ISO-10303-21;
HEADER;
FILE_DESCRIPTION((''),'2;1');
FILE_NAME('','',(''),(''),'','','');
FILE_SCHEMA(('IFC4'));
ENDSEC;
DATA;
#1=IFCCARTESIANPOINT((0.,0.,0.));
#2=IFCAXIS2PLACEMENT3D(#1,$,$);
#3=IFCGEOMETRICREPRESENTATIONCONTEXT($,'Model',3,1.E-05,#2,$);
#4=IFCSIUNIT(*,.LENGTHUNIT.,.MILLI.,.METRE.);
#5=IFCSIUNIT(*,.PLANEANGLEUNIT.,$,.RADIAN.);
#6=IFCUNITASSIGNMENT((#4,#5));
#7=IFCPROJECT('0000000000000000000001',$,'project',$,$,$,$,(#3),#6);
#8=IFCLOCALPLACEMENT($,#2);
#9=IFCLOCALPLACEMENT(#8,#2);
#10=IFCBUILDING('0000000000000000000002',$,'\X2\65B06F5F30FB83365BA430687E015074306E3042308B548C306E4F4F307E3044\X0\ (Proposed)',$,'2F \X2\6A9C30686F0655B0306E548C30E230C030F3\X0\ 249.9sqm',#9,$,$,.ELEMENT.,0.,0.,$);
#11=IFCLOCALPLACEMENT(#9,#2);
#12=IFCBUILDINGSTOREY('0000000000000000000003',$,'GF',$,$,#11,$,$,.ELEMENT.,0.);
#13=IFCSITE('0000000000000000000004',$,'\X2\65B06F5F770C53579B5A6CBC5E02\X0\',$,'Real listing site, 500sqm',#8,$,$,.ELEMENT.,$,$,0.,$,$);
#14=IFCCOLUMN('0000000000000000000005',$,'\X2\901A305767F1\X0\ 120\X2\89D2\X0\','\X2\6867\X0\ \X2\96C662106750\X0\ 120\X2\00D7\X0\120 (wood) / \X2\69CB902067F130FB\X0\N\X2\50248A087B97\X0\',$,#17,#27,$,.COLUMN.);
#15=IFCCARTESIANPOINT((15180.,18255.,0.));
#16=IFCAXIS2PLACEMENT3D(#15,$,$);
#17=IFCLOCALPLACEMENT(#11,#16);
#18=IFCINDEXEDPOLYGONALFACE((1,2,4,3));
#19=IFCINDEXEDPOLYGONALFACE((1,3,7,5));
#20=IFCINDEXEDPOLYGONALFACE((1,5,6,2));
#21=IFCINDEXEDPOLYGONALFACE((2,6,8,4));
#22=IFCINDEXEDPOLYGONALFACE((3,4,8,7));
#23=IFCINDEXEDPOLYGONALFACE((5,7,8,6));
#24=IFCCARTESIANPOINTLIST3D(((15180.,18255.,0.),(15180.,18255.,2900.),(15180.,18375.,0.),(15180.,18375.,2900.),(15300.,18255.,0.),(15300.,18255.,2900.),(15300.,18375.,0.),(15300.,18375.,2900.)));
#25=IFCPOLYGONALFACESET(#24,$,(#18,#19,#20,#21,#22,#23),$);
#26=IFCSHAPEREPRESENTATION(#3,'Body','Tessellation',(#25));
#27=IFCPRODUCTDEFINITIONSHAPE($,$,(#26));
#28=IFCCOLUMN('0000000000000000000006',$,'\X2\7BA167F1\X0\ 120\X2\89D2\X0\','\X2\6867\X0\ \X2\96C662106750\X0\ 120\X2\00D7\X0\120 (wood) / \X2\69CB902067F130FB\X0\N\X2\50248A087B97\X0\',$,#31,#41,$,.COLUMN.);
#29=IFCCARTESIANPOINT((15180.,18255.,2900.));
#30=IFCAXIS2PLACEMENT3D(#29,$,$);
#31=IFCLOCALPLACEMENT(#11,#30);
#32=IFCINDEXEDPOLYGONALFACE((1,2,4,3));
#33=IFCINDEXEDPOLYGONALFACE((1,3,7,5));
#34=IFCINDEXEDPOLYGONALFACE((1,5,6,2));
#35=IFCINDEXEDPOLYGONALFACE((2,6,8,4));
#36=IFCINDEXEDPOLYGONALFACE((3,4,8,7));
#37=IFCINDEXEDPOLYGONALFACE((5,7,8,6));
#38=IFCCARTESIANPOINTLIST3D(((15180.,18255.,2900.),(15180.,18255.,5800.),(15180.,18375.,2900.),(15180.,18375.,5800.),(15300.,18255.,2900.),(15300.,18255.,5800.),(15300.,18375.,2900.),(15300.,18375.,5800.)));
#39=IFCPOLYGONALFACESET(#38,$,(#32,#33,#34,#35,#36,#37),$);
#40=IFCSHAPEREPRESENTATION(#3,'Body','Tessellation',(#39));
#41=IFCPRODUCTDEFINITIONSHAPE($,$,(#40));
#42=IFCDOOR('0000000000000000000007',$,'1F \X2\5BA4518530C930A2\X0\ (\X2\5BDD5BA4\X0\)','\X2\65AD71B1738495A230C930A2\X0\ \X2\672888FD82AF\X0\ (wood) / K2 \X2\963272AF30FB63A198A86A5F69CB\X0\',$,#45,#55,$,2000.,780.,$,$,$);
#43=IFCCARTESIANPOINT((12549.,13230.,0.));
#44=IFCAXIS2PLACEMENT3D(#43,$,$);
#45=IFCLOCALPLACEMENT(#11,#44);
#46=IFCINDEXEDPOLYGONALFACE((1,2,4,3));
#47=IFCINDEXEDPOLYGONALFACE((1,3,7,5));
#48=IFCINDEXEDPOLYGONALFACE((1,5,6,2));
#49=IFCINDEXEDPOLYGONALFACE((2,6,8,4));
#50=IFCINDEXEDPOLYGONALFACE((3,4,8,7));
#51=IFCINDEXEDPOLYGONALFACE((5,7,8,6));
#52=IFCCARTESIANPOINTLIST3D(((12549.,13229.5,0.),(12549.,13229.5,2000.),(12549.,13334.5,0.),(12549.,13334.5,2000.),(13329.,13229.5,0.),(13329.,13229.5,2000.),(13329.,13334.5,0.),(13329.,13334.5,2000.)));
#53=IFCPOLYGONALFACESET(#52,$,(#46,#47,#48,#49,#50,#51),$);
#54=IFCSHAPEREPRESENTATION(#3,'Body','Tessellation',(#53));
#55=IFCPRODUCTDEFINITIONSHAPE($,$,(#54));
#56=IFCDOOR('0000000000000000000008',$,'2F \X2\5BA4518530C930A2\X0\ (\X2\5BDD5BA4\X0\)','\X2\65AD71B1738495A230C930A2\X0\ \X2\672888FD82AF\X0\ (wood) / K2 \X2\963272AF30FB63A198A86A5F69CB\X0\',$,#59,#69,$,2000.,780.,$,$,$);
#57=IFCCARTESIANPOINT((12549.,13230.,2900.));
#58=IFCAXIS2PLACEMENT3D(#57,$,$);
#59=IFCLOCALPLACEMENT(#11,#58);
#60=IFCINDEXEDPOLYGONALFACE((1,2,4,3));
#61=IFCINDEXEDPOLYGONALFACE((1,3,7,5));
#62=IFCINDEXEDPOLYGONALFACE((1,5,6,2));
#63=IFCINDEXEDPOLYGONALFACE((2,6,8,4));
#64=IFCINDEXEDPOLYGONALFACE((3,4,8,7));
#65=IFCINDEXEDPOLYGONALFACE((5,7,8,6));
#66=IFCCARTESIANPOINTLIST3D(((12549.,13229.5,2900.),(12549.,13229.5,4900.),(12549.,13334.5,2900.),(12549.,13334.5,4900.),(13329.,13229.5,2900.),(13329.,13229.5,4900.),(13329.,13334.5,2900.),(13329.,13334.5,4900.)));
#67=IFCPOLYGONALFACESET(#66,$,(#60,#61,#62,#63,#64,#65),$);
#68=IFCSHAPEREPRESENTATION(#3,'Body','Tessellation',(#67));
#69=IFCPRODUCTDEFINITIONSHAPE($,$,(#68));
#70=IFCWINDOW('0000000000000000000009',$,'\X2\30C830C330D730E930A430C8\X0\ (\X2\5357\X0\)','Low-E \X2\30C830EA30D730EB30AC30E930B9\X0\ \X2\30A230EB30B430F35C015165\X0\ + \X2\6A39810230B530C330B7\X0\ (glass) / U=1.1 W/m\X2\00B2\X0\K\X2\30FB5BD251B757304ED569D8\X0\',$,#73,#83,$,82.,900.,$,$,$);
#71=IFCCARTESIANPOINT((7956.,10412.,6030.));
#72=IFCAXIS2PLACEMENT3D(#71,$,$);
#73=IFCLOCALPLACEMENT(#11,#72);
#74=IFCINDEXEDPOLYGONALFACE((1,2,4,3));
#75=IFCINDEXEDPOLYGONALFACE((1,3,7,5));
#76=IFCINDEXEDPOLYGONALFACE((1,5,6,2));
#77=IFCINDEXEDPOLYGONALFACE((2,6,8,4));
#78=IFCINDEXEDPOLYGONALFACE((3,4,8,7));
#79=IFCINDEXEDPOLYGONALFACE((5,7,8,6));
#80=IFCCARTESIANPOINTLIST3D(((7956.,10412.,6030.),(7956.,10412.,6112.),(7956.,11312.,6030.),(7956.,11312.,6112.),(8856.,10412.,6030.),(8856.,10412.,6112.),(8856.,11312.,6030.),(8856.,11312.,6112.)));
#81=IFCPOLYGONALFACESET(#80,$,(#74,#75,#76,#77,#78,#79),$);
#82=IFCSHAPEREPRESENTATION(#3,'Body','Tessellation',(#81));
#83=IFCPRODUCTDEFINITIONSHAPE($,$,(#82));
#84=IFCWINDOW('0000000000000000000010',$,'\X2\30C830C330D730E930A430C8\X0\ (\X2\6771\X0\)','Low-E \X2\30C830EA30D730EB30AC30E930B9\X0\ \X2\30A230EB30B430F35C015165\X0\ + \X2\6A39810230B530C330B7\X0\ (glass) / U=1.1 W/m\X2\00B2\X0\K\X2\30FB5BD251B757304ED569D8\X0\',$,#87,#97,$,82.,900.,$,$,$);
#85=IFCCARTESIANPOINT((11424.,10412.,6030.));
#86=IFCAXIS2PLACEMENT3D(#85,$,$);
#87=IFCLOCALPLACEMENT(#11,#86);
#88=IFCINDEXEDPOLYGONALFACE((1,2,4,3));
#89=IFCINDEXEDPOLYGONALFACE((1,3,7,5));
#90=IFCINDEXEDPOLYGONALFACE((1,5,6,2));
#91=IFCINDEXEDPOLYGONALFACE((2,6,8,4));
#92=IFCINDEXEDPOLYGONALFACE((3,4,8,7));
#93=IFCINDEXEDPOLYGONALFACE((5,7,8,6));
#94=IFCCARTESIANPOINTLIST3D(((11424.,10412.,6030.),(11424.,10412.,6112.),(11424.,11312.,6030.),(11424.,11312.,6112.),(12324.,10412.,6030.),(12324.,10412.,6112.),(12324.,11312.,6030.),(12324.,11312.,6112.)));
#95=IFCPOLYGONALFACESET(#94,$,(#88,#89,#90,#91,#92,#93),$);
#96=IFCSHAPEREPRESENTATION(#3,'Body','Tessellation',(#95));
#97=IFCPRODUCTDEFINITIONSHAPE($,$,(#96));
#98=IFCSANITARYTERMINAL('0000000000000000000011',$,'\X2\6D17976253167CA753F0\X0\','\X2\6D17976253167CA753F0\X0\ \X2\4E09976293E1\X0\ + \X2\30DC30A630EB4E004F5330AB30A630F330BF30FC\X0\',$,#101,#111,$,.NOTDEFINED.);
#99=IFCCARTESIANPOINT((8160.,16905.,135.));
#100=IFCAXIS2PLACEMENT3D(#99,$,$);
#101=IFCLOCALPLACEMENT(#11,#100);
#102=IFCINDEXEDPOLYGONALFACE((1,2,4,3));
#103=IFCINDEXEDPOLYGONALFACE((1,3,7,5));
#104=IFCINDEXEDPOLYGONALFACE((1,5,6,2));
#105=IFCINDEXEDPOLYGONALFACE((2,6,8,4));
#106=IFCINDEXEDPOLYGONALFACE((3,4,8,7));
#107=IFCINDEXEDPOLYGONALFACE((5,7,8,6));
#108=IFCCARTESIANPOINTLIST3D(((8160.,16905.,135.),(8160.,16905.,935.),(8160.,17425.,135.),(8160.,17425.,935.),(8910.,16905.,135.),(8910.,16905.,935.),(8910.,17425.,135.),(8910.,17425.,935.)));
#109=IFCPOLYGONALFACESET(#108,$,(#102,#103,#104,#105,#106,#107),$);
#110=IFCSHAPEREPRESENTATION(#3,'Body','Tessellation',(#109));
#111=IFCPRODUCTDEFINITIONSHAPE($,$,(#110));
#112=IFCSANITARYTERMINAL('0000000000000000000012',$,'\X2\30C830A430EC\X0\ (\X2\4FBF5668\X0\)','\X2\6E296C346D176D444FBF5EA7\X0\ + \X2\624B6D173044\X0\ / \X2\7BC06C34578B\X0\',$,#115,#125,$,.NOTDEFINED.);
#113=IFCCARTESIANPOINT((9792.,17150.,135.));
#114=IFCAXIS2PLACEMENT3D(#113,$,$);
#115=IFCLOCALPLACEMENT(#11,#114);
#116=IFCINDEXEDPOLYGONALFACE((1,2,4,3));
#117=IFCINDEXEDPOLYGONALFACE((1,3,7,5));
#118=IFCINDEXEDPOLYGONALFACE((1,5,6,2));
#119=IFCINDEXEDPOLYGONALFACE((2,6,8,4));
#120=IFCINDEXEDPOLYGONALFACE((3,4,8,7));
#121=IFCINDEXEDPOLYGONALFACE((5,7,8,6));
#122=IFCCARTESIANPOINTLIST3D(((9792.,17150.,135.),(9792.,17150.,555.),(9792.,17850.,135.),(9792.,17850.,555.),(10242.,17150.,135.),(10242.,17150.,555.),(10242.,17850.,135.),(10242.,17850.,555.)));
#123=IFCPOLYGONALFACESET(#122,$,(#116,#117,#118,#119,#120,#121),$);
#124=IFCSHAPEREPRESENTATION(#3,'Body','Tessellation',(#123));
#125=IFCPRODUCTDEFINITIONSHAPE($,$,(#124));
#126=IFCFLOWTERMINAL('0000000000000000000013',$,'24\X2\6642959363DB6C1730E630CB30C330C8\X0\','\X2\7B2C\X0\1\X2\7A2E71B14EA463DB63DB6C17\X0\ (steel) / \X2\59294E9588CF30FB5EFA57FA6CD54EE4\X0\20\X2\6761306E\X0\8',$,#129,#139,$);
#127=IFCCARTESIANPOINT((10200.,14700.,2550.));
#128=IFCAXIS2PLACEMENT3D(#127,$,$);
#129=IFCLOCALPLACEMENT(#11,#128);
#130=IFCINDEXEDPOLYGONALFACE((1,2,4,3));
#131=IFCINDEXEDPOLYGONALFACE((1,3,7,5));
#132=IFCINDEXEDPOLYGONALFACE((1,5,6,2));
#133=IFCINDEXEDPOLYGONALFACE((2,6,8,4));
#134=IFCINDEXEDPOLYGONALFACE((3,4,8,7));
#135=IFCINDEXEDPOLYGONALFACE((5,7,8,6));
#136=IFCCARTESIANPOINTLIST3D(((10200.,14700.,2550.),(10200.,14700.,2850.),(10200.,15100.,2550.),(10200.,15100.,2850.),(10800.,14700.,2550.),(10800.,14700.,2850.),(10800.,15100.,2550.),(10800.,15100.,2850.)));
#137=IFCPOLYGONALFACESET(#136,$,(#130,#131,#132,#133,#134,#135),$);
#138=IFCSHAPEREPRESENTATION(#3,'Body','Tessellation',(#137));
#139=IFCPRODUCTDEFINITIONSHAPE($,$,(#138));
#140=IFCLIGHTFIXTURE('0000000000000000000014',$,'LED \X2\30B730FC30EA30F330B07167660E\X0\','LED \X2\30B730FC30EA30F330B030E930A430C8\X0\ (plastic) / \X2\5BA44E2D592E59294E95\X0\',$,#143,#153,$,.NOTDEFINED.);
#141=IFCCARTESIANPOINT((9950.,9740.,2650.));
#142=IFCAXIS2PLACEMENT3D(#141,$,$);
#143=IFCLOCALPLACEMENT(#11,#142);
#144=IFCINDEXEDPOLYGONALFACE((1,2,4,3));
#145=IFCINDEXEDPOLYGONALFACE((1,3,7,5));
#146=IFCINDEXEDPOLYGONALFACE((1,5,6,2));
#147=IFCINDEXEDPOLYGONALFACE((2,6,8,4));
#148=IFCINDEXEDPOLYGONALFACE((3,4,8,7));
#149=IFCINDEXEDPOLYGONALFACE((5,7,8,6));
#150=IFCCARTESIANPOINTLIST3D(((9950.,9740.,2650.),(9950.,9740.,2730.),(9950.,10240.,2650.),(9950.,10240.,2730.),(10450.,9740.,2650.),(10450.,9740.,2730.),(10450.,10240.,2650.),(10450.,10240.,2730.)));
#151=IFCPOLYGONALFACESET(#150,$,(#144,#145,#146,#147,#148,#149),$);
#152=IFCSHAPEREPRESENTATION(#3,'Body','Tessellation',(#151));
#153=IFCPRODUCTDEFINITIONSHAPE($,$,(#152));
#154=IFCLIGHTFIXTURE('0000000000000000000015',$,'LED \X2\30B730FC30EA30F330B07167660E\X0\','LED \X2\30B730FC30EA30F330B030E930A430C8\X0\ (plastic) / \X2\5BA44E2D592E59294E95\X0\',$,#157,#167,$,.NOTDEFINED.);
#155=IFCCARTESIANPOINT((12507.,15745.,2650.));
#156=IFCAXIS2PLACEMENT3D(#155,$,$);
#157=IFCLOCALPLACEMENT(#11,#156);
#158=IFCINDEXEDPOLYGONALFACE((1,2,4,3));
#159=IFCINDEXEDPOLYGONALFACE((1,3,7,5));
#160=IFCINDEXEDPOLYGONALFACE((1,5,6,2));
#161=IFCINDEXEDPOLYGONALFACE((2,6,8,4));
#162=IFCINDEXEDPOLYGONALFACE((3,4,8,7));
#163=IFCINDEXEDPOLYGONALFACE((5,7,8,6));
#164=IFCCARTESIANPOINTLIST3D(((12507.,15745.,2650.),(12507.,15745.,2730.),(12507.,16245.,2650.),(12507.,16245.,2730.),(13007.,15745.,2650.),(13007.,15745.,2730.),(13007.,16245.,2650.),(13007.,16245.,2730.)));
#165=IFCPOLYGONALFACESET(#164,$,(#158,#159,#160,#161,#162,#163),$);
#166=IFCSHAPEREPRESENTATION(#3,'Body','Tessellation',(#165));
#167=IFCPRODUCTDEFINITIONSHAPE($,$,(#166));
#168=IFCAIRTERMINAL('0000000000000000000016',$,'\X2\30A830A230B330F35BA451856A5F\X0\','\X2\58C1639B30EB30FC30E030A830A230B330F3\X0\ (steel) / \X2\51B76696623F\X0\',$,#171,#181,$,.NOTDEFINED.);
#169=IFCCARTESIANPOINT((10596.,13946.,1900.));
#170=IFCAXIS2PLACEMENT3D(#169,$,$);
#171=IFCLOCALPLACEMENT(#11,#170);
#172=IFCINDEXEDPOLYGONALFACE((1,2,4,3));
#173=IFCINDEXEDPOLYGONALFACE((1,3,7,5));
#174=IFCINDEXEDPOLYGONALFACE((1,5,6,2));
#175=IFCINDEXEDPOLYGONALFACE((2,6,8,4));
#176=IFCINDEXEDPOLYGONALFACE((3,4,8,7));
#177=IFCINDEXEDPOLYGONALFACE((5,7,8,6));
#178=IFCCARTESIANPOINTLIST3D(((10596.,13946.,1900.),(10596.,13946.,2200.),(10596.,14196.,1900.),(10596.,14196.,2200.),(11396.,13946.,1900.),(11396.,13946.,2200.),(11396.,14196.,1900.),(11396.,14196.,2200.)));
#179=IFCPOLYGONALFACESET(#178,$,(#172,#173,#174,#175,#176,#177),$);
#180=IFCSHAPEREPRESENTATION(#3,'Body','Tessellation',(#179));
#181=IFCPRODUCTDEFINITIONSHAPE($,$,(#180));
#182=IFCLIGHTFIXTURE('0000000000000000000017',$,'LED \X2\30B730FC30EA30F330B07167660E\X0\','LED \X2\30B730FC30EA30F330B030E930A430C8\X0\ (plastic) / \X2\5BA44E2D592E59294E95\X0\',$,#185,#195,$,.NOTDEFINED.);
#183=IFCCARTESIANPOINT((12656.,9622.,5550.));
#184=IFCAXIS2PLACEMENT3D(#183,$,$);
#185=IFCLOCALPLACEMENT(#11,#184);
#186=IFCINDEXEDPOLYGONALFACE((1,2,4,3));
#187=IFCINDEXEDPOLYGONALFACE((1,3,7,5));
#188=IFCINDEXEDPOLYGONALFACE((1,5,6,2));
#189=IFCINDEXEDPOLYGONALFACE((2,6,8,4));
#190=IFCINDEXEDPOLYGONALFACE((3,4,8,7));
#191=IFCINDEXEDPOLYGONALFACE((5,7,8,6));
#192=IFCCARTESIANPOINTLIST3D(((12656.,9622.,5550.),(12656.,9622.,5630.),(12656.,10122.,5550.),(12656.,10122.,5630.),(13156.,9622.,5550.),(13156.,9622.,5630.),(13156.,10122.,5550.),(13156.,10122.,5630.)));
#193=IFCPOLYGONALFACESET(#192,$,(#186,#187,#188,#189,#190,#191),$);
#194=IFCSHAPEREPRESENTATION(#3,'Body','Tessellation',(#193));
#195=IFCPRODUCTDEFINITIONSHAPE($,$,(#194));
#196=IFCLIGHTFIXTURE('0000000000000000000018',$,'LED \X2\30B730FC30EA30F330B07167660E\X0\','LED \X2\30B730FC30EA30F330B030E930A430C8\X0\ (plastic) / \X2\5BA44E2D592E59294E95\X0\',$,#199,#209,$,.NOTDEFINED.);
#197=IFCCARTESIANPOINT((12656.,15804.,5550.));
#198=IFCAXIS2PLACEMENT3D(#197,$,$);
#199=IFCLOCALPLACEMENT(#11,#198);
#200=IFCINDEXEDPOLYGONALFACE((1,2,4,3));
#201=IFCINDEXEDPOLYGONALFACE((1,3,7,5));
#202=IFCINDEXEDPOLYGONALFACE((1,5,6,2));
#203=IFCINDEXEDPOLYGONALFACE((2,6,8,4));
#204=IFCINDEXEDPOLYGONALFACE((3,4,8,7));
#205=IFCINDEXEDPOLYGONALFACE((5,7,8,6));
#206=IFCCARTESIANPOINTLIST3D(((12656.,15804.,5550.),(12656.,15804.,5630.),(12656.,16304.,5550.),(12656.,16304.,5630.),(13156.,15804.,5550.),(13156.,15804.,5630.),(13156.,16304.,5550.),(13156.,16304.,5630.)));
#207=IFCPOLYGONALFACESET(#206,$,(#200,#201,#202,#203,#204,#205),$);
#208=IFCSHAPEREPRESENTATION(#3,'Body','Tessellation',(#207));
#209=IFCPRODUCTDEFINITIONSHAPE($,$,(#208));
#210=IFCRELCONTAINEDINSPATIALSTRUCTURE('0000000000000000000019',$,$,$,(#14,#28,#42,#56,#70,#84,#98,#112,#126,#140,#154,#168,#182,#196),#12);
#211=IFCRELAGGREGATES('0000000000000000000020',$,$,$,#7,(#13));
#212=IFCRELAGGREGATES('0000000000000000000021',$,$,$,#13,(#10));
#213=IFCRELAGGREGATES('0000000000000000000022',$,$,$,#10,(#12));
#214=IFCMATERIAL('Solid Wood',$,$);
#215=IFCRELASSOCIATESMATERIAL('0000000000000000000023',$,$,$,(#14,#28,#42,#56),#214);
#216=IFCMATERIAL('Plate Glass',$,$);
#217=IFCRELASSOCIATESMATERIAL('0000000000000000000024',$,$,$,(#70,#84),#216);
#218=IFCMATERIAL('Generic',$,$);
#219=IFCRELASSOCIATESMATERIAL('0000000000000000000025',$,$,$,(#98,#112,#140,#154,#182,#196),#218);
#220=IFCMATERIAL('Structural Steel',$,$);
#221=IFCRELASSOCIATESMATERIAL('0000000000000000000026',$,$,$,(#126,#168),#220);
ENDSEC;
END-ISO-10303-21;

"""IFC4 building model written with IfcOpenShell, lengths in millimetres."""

from ifc_helpers import new_model, si_unit, frame, frame_2d, origin, place, context, project, spatial, rectangle, extrude, material, element, save


model = new_model("IFC4")

# Units and contexts
model_context = context("Model", 3, precision=1e-05, world=origin())
ifc_project = project(units=[si_unit("LENGTHUNIT", "METRE", prefix="MILLI"), si_unit("PLANEANGLEUNIT", "RADIAN")], contexts=[model_context])

# Site, building, storey
site_placement = place(None, origin())
site = spatial("IfcSite", under=ifc_project, at=site_placement, Name="新潟県南魚沼市", ObjectType="Real listing site, 500sqm", CompositionType="ELEMENT", RefElevation=0.0)
building_placement = place(site_placement, origin())
building = spatial("IfcBuilding", under=site, at=building_placement, Name="新潟・茶室と縁側のある和の住まい (Proposed)", ObjectType="2F 檜と漆喰の和モダン 249.9sqm", CompositionType="ELEMENT", ElevationOfRefHeight=0.0, ElevationOfTerrain=0.0)
storey_placement = place(building_placement, origin())
storey = spatial("IfcBuildingStorey", under=building, at=storey_placement, Name="GF", CompositionType="ELEMENT", Elevation=0.0)

# Columns
ifc_material_1 = material(Name="Solid Wood")
column_1_placement = place(storey_placement, frame((15180.0, 18255.0, 0.0)))
element("IfcColumn", 1, at=column_1_placement, inside=storey, material=ifc_material_1, Name="通し柱 120角", Description="桧 集成材 120×120 (wood) / 構造柱・N値計算", PredefinedType="COLUMN", context=model_context, shape_type="SweptSolid", body=[
    extrude(rectangle(XDim=120.0, YDim=120.0, at=frame_2d((60.0, 60.0))), frame((15180.0, 18255.0, 0.0)), (0.0, 0.0, 1.0), 2900.0),
])
column_2_placement = place(storey_placement, frame((15180.0, 18255.0, 2900.0)))
element("IfcColumn", 2, at=column_2_placement, inside=storey, material=ifc_material_1, Name="管柱 120角", Description="桧 集成材 120×120 (wood) / 構造柱・N値計算", PredefinedType="COLUMN", context=model_context, shape_type="SweptSolid", body=[
    extrude(rectangle(XDim=120.0, YDim=120.0, at=frame_2d((60.0, 60.0))), frame((15180.0, 18255.0, 2900.0)), (0.0, 0.0, 1.0), 2900.0),
])

# Door
door_1_placement = place(storey_placement, frame((12549.0, 13230.0, 0.0)))
element("IfcDoor", 3, at=door_1_placement, inside=storey, material=ifc_material_1, Name="1F 室内ドア (寝室)", Description="断熱玄関ドア 木製芯 (wood) / K2 防犯・採風機構", OverallHeight=2000.0, OverallWidth=780.0, context=model_context, shape_type="SweptSolid", body=[
    extrude(rectangle(XDim=780.0, YDim=105.0, at=frame_2d((390.0, 52.0))), frame((12549.0, 13230.0, 0.0)), (0.0, 0.0, 1.0), 2000.0),
])

# Door
door_2_placement = place(storey_placement, frame((12549.0, 13230.0, 2900.0)))
element("IfcDoor", 4, at=door_2_placement, inside=storey, material=ifc_material_1, Name="2F 室内ドア (寝室)", Description="断熱玄関ドア 木製芯 (wood) / K2 防犯・採風機構", OverallHeight=2000.0, OverallWidth=780.0, context=model_context, shape_type="SweptSolid", body=[
    extrude(rectangle(XDim=780.0, YDim=105.0, at=frame_2d((390.0, 52.0))), frame((12549.0, 13230.0, 2900.0)), (0.0, 0.0, 1.0), 2000.0),
])

# Windows
ifc_material_2 = material(Name="Plate Glass")
window_1_placement = place(storey_placement, frame((7956.0, 10412.0, 6030.0)))
element("IfcWindow", 5, at=window_1_placement, inside=storey, material=ifc_material_2, Name="トップライト (南)", Description="Low-E トリプルガラス アルゴン封入 + 樹脂サッシ (glass) / U=1.1 W/m²K・寒冷地仕様", OverallHeight=82.0, OverallWidth=900.0, context=model_context, shape_type="SweptSolid", body=[
    extrude(rectangle(XDim=900.0, YDim=900.0, at=frame_2d((450.0, 450.0))), frame((7956.0, 10412.0, 6030.0)), (0.0, 0.0, 1.0), 82.0),
])
window_2_placement = place(storey_placement, frame((11424.0, 10412.0, 6030.0)))
element("IfcWindow", 6, at=window_2_placement, inside=storey, material=ifc_material_2, Name="トップライト (東)", Description="Low-E トリプルガラス アルゴン封入 + 樹脂サッシ (glass) / U=1.1 W/m²K・寒冷地仕様", OverallHeight=82.0, OverallWidth=900.0, context=model_context, shape_type="SweptSolid", body=[
    extrude(rectangle(XDim=900.0, YDim=900.0, at=frame_2d((450.0, 450.0))), frame((11424.0, 10412.0, 6030.0)), (0.0, 0.0, 1.0), 82.0),
])

# Sanitary terminals
ifc_material_3 = material(Name="Generic")
sanitary_terminal_1_placement = place(storey_placement, frame((8160.0, 16905.0, 135.0)))
element("IfcSanitaryTerminal", 7, at=sanitary_terminal_1_placement, inside=storey, material=ifc_material_3, Name="洗面化粧台", Description="洗面化粧台 三面鏡 + ボウル一体カウンター", PredefinedType="NOTDEFINED", context=model_context, shape_type="SweptSolid", body=[
    extrude(rectangle(XDim=750.0, YDim=520.0, at=frame_2d((375.0, 260.0))), frame((8160.0, 16905.0, 135.0)), (0.0, 0.0, 1.0), 800.0),
])
sanitary_terminal_2_placement = place(storey_placement, frame((9792.0, 17150.0, 135.0)))
element("IfcSanitaryTerminal", 8, at=sanitary_terminal_2_placement, inside=storey, material=ifc_material_3, Name="トイレ (便器)", Description="温水洗浄便座 + 手洗い / 節水型", PredefinedType="NOTDEFINED", context=model_context, shape_type="SweptSolid", body=[
    extrude(rectangle(XDim=450.0, YDim=700.0, at=frame_2d((225.0, 350.0))), frame((9792.0, 17150.0, 135.0)), (0.0, 0.0, 1.0), 420.0),
])

# Flow terminal
ifc_material_4 = material(Name="Structural Steel")
flow_terminal_placement = place(storey_placement, frame((10200.0, 14700.0, 2550.0)))
element("IfcFlowTerminal", 9, at=flow_terminal_placement, inside=storey, material=ifc_material_4, Name="24時間換気ユニット", Description="第1種熱交換換気 (steel) / 天井裏・建基法令20条の8", context=model_context, shape_type="SweptSolid", body=[
    extrude(rectangle(XDim=600.0, YDim=400.0, at=frame_2d((300.0, 200.0))), frame((10200.0, 14700.0, 2550.0)), (0.0, 0.0, 1.0), 300.0),
])

# Light fixtures
light_fixture_1_placement = place(storey_placement, frame((9950.0, 9740.0, 2650.0)))
element("IfcLightFixture", 10, at=light_fixture_1_placement, inside=storey, material=ifc_material_3, Name="LED シーリング照明", Description="LED シーリングライト (plastic) / 室中央天井", PredefinedType="NOTDEFINED", context=model_context, shape_type="SweptSolid", body=[
    extrude(rectangle(XDim=500.0, YDim=500.0, at=frame_2d((250.0, 250.0))), frame((9950.0, 9740.0, 2650.0)), (0.0, 0.0, 1.0), 80.0),
])
light_fixture_2_placement = place(storey_placement, frame((12507.0, 15745.0, 2650.0)))
element("IfcLightFixture", 11, at=light_fixture_2_placement, inside=storey, material=ifc_material_3, Name="LED シーリング照明", Description="LED シーリングライト (plastic) / 室中央天井", PredefinedType="NOTDEFINED", context=model_context, shape_type="SweptSolid", body=[
    extrude(rectangle(XDim=500.0, YDim=500.0, at=frame_2d((250.0, 250.0))), frame((12507.0, 15745.0, 2650.0)), (0.0, 0.0, 1.0), 80.0),
])

# Air terminal
air_terminal_placement = place(storey_placement, frame((10596.0, 13946.0, 1900.0)))
element("IfcAirTerminal", 12, at=air_terminal_placement, inside=storey, material=ifc_material_4, Name="エアコン室内機", Description="壁掛ルームエアコン (steel) / 冷暖房", PredefinedType="NOTDEFINED", context=model_context, shape_type="SweptSolid", body=[
    extrude(rectangle(XDim=800.0, YDim=250.0, at=frame_2d((400.0, 125.0))), frame((10596.0, 13946.0, 1900.0)), (0.0, 0.0, 1.0), 300.0),
])

# Light fixtures
light_fixture_3_placement = place(storey_placement, frame((12656.0, 9622.0, 5550.0)))
element("IfcLightFixture", 13, at=light_fixture_3_placement, inside=storey, material=ifc_material_3, Name="LED シーリング照明", Description="LED シーリングライト (plastic) / 室中央天井", PredefinedType="NOTDEFINED", context=model_context, shape_type="SweptSolid", body=[
    extrude(rectangle(XDim=500.0, YDim=500.0, at=frame_2d((250.0, 250.0))), frame((12656.0, 9622.0, 5550.0)), (0.0, 0.0, 1.0), 80.0),
])
light_fixture_4_placement = place(storey_placement, frame((12656.0, 15804.0, 5550.0)))
element("IfcLightFixture", 14, at=light_fixture_4_placement, inside=storey, material=ifc_material_3, Name="LED シーリング照明", Description="LED シーリングライト (plastic) / 室中央天井", PredefinedType="NOTDEFINED", context=model_context, shape_type="SweptSolid", body=[
    extrude(rectangle(XDim=500.0, YDim=500.0, at=frame_2d((250.0, 250.0))), frame((12656.0, 15804.0, 5550.0)), (0.0, 0.0, 1.0), 80.0),
])

save(model, "model.ifc")
